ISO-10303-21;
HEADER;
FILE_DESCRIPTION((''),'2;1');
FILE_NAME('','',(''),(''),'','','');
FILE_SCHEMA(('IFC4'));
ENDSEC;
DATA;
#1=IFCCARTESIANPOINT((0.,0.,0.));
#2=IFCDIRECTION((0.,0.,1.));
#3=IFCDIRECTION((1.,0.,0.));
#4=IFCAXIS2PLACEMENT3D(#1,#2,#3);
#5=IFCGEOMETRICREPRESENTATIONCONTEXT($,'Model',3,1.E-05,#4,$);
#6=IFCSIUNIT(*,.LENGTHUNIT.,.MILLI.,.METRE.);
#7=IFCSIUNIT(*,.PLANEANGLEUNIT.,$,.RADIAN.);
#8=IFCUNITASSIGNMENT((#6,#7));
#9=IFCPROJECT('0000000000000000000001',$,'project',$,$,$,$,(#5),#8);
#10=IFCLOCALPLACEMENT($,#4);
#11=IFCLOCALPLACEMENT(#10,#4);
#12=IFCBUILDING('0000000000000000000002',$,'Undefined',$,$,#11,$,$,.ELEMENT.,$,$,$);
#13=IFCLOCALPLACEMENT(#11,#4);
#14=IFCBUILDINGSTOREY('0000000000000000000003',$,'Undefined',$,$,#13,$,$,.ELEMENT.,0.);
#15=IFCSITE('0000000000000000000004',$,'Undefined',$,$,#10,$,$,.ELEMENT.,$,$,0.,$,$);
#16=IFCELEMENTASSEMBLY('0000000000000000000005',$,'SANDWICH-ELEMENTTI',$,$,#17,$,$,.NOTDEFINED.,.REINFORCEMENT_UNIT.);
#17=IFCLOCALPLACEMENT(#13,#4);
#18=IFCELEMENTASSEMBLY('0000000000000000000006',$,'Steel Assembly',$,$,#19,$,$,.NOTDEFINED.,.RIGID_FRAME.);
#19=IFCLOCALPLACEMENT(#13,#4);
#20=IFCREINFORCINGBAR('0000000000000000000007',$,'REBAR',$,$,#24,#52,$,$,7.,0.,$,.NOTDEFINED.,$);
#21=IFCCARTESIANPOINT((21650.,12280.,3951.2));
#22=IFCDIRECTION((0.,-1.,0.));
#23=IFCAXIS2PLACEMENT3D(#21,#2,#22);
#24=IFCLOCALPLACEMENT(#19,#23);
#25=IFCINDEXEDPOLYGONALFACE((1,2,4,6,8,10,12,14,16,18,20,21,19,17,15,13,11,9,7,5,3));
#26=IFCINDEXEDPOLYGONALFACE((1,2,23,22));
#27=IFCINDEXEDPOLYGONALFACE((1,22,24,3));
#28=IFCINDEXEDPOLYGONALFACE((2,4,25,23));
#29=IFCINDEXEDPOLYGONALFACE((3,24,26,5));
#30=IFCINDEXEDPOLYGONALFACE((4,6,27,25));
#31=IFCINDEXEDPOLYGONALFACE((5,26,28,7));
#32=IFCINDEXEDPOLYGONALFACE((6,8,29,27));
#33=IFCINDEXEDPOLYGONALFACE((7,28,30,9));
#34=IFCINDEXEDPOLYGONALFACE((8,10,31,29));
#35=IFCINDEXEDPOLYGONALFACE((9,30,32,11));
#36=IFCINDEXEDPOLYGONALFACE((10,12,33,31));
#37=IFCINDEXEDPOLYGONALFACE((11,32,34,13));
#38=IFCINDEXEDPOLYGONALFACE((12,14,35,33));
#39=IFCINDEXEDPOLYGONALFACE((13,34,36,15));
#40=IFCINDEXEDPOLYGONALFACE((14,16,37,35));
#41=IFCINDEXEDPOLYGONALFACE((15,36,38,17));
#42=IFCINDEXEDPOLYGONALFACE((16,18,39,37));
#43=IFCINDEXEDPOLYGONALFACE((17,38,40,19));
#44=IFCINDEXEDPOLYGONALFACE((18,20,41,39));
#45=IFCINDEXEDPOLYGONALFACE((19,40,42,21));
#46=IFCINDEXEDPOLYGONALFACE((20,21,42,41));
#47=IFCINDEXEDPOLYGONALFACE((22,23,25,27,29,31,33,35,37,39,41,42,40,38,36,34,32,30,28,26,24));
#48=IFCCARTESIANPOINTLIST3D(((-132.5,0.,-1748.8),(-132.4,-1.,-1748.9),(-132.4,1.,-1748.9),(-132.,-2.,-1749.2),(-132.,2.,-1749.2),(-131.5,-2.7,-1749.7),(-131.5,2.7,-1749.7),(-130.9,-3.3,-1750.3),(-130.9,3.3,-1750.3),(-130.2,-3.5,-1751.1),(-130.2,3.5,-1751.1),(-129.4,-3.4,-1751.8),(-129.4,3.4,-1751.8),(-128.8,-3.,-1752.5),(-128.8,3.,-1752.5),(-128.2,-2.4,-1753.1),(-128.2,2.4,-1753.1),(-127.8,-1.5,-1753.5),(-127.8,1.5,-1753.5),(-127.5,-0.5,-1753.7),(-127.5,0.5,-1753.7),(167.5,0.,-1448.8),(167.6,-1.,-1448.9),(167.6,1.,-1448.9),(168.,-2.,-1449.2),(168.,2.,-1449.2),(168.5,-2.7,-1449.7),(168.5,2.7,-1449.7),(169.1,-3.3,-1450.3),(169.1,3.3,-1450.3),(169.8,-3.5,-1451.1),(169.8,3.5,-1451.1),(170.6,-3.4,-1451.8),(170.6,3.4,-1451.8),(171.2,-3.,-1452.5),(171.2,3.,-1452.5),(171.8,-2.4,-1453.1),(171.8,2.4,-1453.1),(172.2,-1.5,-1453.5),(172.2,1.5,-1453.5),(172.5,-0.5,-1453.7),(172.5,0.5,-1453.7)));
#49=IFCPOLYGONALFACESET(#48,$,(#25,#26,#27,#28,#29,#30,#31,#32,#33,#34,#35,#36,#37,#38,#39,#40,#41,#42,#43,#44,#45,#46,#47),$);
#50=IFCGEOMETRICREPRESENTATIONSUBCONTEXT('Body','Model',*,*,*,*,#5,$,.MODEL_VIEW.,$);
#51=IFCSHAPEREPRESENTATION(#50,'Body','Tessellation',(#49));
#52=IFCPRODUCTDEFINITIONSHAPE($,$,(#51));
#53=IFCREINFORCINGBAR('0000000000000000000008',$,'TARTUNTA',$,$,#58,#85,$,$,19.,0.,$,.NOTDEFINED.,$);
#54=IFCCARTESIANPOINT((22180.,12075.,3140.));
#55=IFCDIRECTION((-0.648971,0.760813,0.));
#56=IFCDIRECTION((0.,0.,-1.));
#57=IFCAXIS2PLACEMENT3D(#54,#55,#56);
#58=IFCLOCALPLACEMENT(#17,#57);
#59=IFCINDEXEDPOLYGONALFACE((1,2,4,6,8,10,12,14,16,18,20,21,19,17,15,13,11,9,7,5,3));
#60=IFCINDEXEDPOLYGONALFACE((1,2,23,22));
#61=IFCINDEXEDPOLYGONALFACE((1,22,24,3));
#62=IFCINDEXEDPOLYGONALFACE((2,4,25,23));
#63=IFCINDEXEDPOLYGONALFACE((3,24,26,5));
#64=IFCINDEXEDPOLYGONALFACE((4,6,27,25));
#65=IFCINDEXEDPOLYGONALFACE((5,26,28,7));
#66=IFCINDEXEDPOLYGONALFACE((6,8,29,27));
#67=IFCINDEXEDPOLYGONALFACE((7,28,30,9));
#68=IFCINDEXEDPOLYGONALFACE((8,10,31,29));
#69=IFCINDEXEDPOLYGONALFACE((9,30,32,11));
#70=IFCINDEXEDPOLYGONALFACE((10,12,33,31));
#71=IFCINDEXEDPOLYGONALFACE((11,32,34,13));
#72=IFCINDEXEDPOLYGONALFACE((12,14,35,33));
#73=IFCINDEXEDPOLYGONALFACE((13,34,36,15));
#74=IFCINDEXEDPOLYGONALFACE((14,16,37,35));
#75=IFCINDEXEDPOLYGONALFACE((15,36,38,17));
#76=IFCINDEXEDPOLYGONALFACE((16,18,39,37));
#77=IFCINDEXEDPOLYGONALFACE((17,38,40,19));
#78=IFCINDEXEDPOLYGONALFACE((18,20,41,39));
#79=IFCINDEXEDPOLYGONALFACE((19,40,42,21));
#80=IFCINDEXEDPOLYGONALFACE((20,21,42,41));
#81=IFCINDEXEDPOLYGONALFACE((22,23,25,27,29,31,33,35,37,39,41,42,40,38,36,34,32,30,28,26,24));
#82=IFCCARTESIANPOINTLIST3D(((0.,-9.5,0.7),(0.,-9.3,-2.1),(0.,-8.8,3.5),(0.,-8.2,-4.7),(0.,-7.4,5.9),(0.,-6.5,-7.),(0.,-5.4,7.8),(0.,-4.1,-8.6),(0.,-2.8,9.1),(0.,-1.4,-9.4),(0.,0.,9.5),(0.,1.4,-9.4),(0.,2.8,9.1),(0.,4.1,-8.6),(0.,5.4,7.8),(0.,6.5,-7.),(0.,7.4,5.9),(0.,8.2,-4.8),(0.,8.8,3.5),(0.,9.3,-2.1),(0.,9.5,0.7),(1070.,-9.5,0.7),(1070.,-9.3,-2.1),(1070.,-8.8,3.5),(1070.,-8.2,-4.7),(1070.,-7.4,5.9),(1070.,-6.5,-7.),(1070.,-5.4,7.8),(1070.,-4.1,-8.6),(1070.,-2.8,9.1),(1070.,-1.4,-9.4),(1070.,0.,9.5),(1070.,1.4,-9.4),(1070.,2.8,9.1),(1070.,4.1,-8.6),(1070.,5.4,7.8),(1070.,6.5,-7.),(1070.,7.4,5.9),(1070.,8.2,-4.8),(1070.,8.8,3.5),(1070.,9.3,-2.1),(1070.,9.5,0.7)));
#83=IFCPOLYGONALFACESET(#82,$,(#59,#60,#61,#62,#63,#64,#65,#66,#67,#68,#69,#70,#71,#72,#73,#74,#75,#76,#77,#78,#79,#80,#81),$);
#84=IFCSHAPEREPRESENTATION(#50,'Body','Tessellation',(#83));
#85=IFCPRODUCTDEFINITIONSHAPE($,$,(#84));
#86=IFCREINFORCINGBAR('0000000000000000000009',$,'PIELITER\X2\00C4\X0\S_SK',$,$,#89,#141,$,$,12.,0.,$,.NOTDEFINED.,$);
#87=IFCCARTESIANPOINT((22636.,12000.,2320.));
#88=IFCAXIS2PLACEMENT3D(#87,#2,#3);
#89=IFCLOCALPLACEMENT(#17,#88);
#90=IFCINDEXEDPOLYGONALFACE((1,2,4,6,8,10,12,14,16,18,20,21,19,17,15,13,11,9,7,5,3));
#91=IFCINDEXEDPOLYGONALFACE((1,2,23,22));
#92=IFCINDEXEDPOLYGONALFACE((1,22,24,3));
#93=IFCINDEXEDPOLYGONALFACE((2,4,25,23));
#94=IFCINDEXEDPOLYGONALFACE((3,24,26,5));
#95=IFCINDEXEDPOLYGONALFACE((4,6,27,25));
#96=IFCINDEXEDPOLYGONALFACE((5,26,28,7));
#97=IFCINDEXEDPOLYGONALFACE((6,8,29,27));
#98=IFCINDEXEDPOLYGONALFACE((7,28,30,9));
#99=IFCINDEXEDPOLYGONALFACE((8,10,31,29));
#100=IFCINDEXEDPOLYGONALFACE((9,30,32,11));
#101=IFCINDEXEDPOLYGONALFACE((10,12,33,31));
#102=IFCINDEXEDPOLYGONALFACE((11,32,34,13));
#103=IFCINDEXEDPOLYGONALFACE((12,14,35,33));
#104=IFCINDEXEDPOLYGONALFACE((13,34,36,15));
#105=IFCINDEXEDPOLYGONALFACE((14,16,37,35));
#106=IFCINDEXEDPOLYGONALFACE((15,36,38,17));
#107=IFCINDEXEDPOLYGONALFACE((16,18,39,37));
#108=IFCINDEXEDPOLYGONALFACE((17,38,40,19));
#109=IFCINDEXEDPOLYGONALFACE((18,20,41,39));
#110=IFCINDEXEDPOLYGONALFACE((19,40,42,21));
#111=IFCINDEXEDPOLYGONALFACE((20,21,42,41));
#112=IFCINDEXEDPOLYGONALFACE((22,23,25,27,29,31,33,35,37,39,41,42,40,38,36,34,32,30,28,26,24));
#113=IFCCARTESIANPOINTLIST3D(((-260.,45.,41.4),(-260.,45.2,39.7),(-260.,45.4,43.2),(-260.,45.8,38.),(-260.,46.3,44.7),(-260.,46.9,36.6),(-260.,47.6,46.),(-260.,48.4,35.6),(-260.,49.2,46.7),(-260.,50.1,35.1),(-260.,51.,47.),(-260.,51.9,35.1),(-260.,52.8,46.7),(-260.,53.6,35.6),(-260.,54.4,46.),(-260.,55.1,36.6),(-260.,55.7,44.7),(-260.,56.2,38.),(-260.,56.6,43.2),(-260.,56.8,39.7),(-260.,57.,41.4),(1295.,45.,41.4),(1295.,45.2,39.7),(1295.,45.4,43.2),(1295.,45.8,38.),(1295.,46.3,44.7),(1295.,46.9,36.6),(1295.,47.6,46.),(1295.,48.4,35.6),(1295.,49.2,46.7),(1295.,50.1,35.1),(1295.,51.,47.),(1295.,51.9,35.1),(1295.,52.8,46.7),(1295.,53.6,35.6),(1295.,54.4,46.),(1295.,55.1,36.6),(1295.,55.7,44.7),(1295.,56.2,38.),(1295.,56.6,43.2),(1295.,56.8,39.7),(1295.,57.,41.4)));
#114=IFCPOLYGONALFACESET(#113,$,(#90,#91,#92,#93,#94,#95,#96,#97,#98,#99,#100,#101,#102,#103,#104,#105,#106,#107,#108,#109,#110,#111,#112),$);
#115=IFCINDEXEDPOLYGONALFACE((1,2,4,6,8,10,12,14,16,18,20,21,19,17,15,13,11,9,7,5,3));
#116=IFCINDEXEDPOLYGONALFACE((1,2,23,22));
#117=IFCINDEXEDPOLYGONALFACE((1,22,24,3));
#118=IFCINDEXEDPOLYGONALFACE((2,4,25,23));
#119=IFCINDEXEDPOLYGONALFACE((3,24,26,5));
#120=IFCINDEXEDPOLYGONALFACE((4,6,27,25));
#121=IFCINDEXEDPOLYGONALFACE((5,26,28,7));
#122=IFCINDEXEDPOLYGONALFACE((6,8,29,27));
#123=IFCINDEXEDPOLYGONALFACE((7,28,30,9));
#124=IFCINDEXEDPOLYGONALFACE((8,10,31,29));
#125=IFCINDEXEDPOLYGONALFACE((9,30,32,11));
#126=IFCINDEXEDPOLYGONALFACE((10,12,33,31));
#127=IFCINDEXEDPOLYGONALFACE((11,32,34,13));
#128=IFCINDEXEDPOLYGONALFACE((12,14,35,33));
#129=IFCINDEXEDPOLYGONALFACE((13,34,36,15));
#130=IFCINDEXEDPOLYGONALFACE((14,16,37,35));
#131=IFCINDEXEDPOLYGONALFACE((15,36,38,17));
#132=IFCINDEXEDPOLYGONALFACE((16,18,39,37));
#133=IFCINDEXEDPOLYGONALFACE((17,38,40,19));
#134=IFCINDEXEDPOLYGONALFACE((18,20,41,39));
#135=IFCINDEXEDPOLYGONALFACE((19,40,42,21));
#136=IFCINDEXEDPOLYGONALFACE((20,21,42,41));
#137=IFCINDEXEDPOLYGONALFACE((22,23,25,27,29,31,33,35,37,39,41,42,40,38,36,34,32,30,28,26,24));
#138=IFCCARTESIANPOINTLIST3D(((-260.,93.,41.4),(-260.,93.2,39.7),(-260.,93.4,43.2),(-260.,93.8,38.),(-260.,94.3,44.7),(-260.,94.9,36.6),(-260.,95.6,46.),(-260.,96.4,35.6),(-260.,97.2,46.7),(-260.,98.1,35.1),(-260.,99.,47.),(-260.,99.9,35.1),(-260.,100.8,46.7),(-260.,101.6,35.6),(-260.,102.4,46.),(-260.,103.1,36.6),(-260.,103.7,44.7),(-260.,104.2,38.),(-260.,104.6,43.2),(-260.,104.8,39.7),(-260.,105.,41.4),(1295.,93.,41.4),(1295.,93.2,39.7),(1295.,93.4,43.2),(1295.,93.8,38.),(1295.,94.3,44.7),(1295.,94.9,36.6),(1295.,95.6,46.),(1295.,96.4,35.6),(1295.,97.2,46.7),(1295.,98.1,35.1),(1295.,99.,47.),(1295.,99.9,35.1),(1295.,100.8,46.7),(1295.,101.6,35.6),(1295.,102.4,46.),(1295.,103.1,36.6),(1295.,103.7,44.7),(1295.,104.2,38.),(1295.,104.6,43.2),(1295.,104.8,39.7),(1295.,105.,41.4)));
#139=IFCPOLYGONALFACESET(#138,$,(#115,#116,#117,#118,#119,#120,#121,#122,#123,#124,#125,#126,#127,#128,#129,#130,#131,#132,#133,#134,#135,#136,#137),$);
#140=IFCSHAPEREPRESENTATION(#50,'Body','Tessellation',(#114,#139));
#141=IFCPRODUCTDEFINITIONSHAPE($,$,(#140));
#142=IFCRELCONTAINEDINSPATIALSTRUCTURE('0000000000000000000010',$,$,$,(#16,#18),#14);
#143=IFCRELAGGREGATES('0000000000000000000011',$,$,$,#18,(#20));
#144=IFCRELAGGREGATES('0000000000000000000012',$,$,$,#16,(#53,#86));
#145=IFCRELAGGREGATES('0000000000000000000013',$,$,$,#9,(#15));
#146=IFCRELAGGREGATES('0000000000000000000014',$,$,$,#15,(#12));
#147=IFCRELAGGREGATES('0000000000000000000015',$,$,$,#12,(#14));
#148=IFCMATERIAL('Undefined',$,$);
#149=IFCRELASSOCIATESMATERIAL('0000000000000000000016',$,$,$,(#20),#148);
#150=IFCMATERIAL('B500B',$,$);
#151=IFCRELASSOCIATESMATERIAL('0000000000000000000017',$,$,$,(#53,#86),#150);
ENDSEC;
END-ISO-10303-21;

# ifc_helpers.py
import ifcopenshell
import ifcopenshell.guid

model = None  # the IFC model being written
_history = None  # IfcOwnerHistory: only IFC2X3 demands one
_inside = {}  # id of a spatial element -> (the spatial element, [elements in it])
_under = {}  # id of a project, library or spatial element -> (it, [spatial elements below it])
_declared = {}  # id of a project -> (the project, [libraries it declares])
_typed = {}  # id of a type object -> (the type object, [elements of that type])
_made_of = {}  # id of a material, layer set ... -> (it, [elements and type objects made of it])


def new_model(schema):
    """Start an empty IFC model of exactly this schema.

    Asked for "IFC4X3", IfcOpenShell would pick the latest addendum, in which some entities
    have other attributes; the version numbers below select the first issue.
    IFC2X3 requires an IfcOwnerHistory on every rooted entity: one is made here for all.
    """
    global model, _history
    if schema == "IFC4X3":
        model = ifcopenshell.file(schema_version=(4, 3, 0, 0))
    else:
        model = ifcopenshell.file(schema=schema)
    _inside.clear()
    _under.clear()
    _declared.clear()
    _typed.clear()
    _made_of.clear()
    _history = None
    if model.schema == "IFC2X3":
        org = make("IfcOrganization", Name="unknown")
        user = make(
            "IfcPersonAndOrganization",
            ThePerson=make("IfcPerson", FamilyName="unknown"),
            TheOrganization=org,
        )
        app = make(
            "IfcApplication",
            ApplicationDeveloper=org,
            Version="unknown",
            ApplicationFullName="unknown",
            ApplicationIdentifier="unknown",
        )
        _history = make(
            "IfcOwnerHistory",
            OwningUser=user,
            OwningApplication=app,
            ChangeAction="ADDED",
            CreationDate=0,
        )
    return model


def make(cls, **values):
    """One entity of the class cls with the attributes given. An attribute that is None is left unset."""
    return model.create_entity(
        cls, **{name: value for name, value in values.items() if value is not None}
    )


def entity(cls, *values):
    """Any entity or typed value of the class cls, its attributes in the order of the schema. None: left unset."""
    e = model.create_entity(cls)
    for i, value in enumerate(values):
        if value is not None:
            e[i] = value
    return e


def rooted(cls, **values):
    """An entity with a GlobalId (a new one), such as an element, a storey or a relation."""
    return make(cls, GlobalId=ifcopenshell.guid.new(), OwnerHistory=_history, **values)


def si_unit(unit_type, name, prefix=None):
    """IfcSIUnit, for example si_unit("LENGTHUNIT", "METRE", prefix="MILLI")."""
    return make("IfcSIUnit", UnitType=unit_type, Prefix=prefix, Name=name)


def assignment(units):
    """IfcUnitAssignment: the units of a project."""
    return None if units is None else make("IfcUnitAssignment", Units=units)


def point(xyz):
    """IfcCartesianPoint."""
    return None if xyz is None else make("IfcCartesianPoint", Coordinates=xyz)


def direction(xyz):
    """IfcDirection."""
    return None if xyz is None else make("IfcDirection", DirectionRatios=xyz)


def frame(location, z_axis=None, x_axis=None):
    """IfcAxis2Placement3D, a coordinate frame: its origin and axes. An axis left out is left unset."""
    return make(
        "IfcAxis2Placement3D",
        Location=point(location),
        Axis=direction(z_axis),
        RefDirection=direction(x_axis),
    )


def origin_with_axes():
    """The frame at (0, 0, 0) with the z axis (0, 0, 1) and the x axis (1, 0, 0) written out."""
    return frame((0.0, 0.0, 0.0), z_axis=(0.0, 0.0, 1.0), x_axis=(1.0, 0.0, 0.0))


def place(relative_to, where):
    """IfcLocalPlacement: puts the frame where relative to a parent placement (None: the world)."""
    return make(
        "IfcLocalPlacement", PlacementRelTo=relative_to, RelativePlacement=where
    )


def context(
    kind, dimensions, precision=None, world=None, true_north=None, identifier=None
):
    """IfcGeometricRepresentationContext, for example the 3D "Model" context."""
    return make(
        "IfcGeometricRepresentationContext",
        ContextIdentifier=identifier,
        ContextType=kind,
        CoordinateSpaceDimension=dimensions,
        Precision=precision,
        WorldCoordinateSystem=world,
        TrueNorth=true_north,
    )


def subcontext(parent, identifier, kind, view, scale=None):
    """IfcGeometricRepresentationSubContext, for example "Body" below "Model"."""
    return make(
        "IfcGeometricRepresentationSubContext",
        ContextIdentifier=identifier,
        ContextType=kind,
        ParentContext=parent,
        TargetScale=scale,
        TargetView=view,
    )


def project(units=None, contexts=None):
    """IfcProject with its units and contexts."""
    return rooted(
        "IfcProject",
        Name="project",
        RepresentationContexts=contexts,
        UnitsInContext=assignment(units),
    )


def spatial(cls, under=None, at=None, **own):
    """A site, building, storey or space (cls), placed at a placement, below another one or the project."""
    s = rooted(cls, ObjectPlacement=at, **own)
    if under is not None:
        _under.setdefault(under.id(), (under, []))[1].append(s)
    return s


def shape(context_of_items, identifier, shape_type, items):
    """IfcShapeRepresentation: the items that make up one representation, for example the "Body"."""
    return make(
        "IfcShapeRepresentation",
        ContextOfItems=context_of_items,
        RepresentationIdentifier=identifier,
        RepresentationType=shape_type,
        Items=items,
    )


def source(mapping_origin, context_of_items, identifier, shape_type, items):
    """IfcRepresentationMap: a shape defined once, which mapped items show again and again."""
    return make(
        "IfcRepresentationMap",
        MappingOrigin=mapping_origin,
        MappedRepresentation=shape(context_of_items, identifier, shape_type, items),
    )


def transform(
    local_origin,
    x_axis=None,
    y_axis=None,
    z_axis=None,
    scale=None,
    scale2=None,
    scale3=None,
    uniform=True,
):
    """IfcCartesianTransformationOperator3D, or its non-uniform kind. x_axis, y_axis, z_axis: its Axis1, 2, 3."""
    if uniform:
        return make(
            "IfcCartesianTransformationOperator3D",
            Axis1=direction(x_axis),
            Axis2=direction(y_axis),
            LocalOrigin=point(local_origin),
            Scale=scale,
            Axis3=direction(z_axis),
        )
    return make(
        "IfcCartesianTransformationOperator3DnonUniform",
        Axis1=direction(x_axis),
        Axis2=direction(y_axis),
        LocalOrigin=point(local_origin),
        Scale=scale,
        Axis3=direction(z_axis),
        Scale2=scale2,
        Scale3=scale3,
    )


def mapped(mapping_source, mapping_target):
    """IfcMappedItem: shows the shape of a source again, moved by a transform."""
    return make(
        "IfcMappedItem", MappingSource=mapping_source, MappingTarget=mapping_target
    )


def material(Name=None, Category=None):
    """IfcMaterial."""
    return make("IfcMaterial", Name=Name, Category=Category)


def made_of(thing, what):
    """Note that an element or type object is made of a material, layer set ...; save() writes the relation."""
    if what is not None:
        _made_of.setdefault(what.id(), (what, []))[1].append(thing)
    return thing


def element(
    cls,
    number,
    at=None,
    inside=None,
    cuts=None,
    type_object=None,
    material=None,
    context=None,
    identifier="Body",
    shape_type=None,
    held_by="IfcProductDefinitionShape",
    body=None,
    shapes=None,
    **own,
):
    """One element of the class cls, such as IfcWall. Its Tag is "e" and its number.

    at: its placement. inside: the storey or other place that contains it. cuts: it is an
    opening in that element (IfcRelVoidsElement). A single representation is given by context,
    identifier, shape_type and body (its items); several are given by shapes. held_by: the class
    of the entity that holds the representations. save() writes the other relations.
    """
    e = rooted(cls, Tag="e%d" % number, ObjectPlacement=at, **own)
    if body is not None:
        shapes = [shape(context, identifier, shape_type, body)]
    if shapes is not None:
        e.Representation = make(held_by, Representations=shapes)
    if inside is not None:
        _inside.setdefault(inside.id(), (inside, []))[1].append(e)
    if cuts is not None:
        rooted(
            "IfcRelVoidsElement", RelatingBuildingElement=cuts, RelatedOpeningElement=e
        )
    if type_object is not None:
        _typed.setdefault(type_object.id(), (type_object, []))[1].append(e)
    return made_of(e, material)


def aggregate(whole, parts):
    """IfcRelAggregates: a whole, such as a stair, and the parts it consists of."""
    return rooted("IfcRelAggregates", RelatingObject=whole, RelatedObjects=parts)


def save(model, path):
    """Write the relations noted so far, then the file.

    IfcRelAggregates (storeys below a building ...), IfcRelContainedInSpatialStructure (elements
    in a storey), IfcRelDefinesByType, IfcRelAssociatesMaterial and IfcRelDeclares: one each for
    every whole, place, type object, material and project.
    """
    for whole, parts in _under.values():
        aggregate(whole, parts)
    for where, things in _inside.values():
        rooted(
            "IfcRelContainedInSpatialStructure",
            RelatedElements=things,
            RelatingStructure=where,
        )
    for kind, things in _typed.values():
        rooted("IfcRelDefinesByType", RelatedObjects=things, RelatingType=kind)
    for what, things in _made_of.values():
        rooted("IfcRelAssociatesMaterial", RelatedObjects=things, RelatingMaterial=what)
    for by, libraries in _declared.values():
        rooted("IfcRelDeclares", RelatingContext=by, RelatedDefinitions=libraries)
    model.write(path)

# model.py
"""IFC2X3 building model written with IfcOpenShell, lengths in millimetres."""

from ifc_helpers import new_model, entity, si_unit, frame, origin_with_axes, place, context, subcontext, project, spatial, source, transform, mapped, material, element, aggregate, save


model = new_model("IFC2X3")

# Units and contexts
model_context = context("Model", 3, precision=1e-05, world=origin_with_axes())
body_context = subcontext(model_context, "Body", "Model", "MODEL_VIEW")
ifc_project = project(units=[si_unit("LENGTHUNIT", "METRE", prefix="MILLI"), si_unit("PLANEANGLEUNIT", "RADIAN")], contexts=[model_context])

# Site, building, storey
site_placement = place(None, origin_with_axes())
site = spatial("IfcSite", under=ifc_project, at=site_placement, Name="Undefined", CompositionType="ELEMENT", RefElevation=0.0)
building_placement = place(site_placement, origin_with_axes())
building = spatial("IfcBuilding", under=site, at=building_placement, Name="Undefined", CompositionType="ELEMENT")
storey_placement = place(building_placement, origin_with_axes())
storey = spatial("IfcBuildingStorey", under=building, at=storey_placement, Name="Undefined", CompositionType="ELEMENT", Elevation=0.0)

# Element assembly
assembly_1_placement = place(storey_placement, origin_with_axes())
assembly_1 = element("IfcElementAssembly", 1, at=assembly_1_placement, inside=storey, Name="SANDWICH-ELEMENTTI", AssemblyPlace="NOTDEFINED", PredefinedType="REINFORCEMENT_UNIT")

# Shared definitions
ifc_material_1 = material(Name="Undefined")

# Element assembly, reinforcing bar
assembly_2_placement = place(storey_placement, origin_with_axes())
assembly_2 = element("IfcElementAssembly", 2, at=assembly_2_placement, inside=storey, Name="Steel Assembly", AssemblyPlace="NOTDEFINED", PredefinedType="RIGID_FRAME")
shared_shape_1 = source(origin_with_axes(), body_context, "Body", "AdvancedSweptSolid", [
    entity("IfcSweptDiskSolid", entity("IfcTrimmedCurve", entity("IfcLine", entity("IfcCartesianPoint", [0.0, 0.0, 0.0]), entity("IfcVector", entity("IfcDirection", [0.707107, 0.0, 0.707107]), 1.0)), [entity("IfcParameterValue", 0.0)], [entity("IfcParameterValue", 424.264069)], True, "PARAMETER"), 3.5, None, 0.0, 424.3),
])
reinforcing_bar_1_placement = place(assembly_2_placement, frame((21650.0, 12280.0, 3951.2), z_axis=(0.0, 0.0, 1.0), x_axis=(0.0, -1.0, 0.0)))
reinforcing_bar_1 = element("IfcReinforcingBar", 3, at=reinforcing_bar_1_placement, material=ifc_material_1, Name="REBAR", BarRole="NOTDEFINED", CrossSectionArea=0.0, NominalDiameter=7.0, context=body_context, shape_type="MappedRepresentation", body=[
    mapped(shared_shape_1, transform((-130.0, 0.0, -1751.2))),
])
aggregate(assembly_2, [reinforcing_bar_1])

# Reinforcing bars
ifc_material_2 = material(Name="B500B")
shared_shape_2 = source(origin_with_axes(), body_context, "Body", "AdvancedSweptSolid", [
    entity("IfcSweptDiskSolid", entity("IfcTrimmedCurve", entity("IfcLine", entity("IfcCartesianPoint", [0.0, 0.0, 0.0]), entity("IfcVector", entity("IfcDirection", [1.0, 0.0, 0.0]), 1.0)), [entity("IfcParameterValue", 0.0)], [entity("IfcParameterValue", 1070.0)], True, "PARAMETER"), 9.5, None, 0.0, 1070.0),
])
reinforcing_bar_2_placement = place(assembly_1_placement, frame((22180.0, 12075.0, 3140.0), z_axis=(-0.648971, 0.760813, 0.0), x_axis=(0.0, 0.0, -1.0)))
reinforcing_bar_2 = element("IfcReinforcingBar", 4, at=reinforcing_bar_2_placement, material=ifc_material_2, Name="TARTUNTA", BarRole="NOTDEFINED", CrossSectionArea=0.0, NominalDiameter=19.0, context=body_context, shape_type="MappedRepresentation", body=[
    mapped(shared_shape_2, transform((0.0, 0.0, 0.0))),
])
shared_shape_3 = source(origin_with_axes(), body_context, "Body", "AdvancedSweptSolid", [
    entity("IfcSweptDiskSolid", entity("IfcTrimmedCurve", entity("IfcLine", entity("IfcCartesianPoint", [0.0, 0.0, 0.0]), entity("IfcVector", entity("IfcDirection", [1.0, 0.0, 0.0]), 1.0)), [entity("IfcParameterValue", 0.0)], [entity("IfcParameterValue", 1555.0)], True, "PARAMETER"), 6.0, None, 0.0, 1555.0),
])
shared_shape_4 = source(origin_with_axes(), body_context, "Body", "AdvancedSweptSolid", [
    entity("IfcSweptDiskSolid", entity("IfcTrimmedCurve", entity("IfcLine", entity("IfcCartesianPoint", [0.0, 0.0, 0.0]), entity("IfcVector", entity("IfcDirection", [1.0, 0.0, 0.0]), 1.0)), [entity("IfcParameterValue", 0.0)], [entity("IfcParameterValue", 1555.0)], True, "PARAMETER"), 6.0, None, 0.0, 1555.0),
])
reinforcing_bar_3_placement = place(assembly_1_placement, frame((22636.0, 12000.0, 2320.0), z_axis=(0.0, 0.0, 1.0), x_axis=(1.0, 0.0, 0.0)))
reinforcing_bar_3 = element("IfcReinforcingBar", 5, at=reinforcing_bar_3_placement, material=ifc_material_2, Name="PIELITERÄS_SK", BarRole="NOTDEFINED", CrossSectionArea=0.0, NominalDiameter=12.0, context=body_context, shape_type="MappedRepresentation", body=[
    mapped(shared_shape_3, transform((-260.0, 51.0, 41.0))),
    mapped(shared_shape_4, transform((-260.0, 99.0, 41.0))),
])
aggregate(assembly_1, [reinforcing_bar_2, reinforcing_bar_3])

save(model, "model.ifc")
